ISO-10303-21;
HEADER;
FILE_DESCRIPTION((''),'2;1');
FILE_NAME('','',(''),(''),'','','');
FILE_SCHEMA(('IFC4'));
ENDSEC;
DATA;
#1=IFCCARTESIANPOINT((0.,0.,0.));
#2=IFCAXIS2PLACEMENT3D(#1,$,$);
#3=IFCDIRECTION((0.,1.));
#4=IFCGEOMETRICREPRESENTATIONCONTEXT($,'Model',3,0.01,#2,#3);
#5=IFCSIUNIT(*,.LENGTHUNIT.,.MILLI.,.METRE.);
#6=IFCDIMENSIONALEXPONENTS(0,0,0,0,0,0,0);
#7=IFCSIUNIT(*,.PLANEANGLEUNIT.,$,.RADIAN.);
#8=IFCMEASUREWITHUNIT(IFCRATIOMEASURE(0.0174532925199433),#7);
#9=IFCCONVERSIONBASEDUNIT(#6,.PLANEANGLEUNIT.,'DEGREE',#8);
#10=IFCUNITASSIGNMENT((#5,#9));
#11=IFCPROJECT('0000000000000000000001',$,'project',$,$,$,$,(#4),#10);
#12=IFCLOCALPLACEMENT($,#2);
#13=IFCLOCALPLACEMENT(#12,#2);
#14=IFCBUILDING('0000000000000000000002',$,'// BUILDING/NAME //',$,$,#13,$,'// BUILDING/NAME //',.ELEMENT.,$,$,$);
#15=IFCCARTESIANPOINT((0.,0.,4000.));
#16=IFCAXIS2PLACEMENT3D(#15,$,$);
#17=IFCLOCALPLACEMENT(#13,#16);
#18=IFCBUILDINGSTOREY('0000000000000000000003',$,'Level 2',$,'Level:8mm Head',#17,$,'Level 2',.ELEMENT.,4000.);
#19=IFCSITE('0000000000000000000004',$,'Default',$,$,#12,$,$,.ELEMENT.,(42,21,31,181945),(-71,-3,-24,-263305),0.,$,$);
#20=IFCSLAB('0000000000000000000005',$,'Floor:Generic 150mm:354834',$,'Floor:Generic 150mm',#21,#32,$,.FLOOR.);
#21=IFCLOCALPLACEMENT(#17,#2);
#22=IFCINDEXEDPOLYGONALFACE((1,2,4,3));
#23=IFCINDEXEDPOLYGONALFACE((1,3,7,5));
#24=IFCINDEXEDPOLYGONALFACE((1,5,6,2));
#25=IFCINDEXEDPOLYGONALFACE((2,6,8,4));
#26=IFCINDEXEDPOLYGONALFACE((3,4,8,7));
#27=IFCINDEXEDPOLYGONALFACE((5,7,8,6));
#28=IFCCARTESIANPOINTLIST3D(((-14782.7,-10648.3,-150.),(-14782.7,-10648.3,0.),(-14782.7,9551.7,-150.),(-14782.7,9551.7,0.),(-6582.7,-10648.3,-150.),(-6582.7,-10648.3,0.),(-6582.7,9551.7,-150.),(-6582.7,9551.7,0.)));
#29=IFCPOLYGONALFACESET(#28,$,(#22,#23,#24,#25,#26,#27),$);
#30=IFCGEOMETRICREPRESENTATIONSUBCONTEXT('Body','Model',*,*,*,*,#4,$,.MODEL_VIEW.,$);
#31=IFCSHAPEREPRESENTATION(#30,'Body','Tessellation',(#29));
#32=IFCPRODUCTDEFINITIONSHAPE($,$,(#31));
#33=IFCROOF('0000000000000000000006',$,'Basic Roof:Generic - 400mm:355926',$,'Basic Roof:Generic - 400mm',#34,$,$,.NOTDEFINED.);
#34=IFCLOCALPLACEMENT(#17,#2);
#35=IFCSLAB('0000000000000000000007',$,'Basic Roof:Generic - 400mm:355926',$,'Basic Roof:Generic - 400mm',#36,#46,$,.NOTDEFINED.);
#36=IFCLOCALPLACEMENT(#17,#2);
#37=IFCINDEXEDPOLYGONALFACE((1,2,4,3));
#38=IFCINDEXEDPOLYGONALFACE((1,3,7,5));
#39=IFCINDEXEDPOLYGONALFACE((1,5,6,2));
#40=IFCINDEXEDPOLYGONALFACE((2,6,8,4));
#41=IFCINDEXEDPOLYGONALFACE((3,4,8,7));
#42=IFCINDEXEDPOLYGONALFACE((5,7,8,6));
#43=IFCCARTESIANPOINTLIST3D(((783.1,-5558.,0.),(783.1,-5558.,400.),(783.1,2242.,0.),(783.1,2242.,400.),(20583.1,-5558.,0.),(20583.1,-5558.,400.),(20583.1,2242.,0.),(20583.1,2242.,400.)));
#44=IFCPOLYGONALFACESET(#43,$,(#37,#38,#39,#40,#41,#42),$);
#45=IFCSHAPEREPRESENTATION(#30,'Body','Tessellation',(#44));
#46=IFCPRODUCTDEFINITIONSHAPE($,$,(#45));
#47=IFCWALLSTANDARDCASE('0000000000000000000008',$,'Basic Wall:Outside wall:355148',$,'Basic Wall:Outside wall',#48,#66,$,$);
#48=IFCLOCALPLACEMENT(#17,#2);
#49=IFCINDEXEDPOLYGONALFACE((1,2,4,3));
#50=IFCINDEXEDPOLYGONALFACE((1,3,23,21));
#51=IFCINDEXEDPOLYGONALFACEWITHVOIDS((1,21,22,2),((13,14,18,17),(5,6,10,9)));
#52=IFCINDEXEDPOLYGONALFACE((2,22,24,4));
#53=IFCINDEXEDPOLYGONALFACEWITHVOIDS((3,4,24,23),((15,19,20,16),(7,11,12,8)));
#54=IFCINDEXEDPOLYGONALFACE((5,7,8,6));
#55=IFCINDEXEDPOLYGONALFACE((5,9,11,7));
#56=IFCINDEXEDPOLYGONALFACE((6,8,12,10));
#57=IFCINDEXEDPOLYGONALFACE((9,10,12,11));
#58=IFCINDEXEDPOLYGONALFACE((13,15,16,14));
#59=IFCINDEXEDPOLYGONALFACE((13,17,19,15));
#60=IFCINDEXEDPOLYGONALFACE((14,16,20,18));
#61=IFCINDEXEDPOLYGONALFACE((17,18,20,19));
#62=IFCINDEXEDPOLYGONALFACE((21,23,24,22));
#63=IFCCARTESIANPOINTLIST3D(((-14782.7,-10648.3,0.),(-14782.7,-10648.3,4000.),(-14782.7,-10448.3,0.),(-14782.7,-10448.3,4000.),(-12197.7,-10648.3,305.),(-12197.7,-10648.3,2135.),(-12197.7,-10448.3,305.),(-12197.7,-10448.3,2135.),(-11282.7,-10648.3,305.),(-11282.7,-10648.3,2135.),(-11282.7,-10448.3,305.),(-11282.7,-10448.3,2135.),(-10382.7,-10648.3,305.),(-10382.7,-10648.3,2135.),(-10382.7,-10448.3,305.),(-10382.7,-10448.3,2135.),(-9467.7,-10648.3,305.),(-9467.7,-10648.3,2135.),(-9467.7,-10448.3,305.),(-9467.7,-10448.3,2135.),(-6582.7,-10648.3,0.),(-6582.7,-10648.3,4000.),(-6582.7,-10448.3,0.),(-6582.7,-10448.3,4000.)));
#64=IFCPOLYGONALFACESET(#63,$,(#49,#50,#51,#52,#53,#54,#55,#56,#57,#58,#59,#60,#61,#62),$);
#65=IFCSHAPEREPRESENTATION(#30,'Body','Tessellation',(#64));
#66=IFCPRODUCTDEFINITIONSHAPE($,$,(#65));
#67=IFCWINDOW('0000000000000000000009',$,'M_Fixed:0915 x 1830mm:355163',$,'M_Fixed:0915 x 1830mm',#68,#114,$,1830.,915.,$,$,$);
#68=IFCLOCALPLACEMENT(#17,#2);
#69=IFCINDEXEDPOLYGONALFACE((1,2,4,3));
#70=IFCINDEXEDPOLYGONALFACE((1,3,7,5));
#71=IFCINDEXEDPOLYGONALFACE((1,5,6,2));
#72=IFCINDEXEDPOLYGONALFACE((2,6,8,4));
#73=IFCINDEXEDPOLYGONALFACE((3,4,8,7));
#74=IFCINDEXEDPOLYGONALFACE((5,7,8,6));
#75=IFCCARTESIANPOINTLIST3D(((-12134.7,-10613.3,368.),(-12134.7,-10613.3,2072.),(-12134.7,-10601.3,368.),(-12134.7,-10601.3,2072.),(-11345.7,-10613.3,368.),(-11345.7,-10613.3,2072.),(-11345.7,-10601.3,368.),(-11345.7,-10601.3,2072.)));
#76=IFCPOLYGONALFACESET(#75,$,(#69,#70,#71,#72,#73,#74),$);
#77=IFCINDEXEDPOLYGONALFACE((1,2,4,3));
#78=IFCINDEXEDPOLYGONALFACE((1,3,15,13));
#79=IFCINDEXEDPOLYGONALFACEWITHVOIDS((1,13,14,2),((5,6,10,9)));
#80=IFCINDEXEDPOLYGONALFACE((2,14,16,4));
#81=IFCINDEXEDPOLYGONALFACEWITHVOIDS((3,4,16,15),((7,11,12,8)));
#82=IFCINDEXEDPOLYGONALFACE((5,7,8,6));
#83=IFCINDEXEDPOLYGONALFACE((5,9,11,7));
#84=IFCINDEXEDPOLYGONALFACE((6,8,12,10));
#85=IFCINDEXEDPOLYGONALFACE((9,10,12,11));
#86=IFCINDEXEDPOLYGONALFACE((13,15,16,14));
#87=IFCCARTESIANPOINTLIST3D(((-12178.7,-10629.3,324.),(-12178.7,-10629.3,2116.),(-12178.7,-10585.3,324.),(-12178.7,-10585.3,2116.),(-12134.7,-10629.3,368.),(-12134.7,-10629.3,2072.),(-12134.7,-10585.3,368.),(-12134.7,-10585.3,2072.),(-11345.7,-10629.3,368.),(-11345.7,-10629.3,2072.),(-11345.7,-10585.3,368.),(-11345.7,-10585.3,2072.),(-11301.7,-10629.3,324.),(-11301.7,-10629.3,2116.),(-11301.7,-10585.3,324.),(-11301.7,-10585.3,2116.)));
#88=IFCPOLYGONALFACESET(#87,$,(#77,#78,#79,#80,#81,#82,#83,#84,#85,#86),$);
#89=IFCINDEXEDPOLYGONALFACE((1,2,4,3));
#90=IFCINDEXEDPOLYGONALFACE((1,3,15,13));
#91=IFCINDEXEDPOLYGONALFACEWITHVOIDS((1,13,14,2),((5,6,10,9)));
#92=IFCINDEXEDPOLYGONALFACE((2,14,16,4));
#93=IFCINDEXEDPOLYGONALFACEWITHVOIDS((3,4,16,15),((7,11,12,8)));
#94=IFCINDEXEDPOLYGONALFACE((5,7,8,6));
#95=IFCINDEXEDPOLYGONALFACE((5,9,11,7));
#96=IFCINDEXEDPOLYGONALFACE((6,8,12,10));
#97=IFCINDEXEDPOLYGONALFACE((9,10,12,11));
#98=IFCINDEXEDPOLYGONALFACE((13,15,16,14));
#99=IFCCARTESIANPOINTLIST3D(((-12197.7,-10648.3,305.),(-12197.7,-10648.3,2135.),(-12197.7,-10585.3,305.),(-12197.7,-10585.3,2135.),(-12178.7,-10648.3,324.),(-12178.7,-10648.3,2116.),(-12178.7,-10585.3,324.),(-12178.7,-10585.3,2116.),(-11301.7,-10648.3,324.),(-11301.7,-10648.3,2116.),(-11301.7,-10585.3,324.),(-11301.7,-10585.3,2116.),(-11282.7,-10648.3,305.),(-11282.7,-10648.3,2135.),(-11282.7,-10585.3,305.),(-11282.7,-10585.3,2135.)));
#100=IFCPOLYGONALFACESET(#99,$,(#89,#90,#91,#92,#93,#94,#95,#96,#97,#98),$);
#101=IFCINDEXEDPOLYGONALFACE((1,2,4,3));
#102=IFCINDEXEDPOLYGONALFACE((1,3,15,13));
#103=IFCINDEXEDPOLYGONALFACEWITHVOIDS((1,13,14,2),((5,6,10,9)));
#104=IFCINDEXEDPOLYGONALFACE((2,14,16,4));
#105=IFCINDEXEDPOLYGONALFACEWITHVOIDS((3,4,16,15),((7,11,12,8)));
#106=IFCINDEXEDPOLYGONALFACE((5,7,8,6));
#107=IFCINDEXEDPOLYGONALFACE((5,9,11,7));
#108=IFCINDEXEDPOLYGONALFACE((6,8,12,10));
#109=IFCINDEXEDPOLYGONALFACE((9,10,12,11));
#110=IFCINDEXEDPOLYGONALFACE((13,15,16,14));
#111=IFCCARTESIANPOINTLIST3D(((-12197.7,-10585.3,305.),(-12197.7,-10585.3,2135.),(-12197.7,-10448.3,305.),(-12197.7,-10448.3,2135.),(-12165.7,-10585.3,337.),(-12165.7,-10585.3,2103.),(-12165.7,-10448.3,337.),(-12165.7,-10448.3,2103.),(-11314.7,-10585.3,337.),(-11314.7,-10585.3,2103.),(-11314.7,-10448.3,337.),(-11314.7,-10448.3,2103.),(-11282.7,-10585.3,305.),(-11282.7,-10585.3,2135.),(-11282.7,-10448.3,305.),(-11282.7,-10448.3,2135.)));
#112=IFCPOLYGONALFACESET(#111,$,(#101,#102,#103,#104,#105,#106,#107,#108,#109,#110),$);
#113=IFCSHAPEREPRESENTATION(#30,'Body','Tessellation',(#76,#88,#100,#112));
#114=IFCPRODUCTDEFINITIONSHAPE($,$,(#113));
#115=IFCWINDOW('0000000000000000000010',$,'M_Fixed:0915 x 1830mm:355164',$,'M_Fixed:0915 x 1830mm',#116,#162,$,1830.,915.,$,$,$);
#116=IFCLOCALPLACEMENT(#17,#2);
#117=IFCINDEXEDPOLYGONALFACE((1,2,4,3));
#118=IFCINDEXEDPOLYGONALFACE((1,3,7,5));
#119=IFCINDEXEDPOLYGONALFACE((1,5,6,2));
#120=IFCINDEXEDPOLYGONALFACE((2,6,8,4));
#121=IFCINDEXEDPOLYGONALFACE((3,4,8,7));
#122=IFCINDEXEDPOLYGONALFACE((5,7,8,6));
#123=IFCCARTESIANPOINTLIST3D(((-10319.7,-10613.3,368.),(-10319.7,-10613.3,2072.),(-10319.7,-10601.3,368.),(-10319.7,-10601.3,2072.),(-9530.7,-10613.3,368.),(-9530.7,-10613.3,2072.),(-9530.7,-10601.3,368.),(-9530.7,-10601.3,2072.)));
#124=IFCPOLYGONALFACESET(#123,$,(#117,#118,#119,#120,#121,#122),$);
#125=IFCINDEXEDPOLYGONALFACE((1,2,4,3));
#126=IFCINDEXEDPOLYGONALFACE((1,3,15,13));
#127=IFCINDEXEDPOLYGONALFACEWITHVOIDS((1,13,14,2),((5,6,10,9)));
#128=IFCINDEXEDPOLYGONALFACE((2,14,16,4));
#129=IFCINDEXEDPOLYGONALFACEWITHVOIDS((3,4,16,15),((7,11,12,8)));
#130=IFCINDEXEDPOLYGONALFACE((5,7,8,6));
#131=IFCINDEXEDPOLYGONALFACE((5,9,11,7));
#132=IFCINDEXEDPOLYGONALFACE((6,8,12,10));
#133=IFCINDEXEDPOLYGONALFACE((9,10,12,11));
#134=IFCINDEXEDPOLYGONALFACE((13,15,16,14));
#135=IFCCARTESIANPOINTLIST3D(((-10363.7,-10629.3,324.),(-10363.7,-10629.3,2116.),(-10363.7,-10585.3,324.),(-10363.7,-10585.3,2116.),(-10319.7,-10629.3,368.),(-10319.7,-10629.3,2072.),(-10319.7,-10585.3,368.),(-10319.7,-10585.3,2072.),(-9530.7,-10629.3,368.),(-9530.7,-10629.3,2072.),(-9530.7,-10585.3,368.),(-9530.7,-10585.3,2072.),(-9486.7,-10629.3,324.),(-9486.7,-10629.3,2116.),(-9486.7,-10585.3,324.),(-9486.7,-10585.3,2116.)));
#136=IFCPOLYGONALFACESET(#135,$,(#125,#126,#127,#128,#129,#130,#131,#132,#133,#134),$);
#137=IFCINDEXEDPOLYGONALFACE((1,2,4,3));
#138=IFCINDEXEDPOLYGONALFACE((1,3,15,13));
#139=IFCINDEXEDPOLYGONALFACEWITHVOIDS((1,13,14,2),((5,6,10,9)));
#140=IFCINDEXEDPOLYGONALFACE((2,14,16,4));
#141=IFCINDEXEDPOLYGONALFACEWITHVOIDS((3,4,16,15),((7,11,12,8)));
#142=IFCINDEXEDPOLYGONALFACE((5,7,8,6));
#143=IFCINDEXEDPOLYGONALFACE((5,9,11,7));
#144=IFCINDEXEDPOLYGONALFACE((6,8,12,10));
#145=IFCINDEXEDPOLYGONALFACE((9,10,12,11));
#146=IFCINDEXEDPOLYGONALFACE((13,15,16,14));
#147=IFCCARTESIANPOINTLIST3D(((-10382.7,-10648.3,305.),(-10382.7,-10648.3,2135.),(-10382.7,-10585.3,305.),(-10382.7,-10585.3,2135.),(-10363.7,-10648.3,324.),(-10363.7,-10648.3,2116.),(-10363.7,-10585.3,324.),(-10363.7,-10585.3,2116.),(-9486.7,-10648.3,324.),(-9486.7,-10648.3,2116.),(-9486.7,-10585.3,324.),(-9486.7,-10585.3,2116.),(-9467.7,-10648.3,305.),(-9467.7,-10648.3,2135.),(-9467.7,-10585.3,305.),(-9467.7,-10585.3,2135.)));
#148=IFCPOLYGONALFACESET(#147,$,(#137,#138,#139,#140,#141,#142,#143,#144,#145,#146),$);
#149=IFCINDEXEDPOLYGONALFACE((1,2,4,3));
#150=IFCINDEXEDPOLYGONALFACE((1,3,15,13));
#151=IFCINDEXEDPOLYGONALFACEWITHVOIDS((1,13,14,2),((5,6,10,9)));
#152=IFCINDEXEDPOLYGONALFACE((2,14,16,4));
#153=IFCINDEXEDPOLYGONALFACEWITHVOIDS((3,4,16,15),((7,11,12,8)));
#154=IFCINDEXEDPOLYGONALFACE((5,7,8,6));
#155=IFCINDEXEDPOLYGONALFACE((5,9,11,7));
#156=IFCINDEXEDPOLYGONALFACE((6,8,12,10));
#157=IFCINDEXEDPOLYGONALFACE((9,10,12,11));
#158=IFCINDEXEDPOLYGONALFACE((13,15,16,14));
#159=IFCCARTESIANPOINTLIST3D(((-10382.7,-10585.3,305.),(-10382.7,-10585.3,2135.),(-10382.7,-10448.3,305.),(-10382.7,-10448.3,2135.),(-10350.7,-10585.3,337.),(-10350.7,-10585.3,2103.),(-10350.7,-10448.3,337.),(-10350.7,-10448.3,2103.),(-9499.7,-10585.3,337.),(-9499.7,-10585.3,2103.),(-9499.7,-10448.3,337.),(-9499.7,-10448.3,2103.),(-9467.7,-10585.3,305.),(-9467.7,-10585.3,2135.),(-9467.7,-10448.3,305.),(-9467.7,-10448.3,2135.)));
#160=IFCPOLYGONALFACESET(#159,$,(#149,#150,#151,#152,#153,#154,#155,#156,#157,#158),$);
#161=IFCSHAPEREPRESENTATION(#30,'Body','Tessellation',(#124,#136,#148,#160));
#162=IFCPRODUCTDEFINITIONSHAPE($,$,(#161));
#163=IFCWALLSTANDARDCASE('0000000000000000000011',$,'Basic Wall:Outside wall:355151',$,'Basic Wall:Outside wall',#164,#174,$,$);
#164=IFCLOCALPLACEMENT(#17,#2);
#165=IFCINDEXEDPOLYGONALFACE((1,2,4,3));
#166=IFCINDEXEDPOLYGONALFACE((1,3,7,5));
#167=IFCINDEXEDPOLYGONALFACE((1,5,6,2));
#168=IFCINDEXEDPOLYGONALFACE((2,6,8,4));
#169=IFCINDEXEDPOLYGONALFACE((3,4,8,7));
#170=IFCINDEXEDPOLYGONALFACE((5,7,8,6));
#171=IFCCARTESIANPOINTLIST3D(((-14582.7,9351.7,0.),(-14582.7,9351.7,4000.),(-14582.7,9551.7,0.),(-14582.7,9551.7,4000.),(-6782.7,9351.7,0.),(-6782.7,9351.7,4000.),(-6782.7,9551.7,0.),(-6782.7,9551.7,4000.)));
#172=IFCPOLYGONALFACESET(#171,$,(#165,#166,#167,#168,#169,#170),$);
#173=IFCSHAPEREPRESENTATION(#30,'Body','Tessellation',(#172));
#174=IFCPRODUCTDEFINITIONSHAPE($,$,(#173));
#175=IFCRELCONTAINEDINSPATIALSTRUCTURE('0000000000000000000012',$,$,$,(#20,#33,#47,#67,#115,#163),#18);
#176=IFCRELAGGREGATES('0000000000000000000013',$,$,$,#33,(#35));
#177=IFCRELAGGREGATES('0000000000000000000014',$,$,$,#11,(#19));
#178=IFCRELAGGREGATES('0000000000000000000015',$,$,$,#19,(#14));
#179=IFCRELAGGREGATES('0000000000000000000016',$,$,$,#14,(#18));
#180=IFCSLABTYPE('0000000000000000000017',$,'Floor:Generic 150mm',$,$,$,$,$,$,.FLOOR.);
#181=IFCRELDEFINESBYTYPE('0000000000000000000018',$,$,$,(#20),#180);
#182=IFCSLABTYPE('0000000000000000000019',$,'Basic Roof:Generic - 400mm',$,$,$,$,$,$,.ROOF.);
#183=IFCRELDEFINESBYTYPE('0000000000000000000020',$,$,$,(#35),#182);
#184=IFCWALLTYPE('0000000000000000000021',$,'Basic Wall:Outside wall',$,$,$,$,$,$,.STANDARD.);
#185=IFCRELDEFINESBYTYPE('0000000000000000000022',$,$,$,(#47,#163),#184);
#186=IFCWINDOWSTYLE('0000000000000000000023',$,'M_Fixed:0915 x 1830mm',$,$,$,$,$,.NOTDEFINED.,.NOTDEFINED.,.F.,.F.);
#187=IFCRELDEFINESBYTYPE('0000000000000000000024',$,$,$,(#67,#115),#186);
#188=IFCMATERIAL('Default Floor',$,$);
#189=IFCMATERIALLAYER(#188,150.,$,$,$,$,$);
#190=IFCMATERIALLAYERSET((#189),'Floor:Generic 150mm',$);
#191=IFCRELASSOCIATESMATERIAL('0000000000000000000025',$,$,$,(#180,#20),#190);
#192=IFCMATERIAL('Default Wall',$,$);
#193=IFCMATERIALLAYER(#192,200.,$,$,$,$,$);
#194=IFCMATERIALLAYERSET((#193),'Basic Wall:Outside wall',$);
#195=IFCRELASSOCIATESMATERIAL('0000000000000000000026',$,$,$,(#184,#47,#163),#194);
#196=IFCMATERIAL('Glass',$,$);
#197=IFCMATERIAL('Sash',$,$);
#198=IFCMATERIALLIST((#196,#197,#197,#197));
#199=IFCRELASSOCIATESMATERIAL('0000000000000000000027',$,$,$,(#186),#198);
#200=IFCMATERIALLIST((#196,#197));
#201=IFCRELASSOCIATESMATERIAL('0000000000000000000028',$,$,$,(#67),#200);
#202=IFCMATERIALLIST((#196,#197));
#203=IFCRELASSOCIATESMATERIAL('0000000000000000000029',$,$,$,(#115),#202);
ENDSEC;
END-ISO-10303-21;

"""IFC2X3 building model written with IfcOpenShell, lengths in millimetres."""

from ifc_helpers import new_model, entity, si_unit, converted_unit, direction, frame, frame_2d, origin, place, context, subcontext, project, spatial, polyline, rectangle, outline, extrude, source, transform, mapped, material, material_list, layer, layer_set, layer_usage, type_object, type_shapes, element, fill, aggregate, save


model = new_model("IFC2X3")

# Units and contexts
model_context = context("Model", 3, precision=0.01, world=origin(), true_north=direction((0.0, 1.0)))
body_context = subcontext(model_context, "Body", "Model", "MODEL_VIEW")
ifc_project = project(units=[si_unit("LENGTHUNIT", "METRE", prefix="MILLI"), converted_unit("PLANEANGLEUNIT", "DEGREE", entity("IfcRatioMeasure", 0.0174532925199433), si_unit("PLANEANGLEUNIT", "RADIAN"), dimensions=[0, 0, 0, 0, 0, 0, 0])], contexts=[model_context])

# Site, building, storey
site_placement = place(None, origin())
site = spatial("IfcSite", under=ifc_project, at=site_placement, Name="Default", CompositionType="ELEMENT", RefLatitude=(42, 21, 31, 181945), RefLongitude=(-71, -3, -24, -263305), RefElevation=0.0)
building_placement = place(site_placement, origin())
building = spatial("IfcBuilding", under=site, at=building_placement, Name="// BUILDING/NAME //", LongName="// BUILDING/NAME //", CompositionType="ELEMENT")
storey_placement = place(building_placement, frame((0.0, 0.0, 4000.0)))
storey = spatial("IfcBuildingStorey", under=building, at=storey_placement, Name="Level 2", ObjectType="Level:8mm Head", LongName="Level 2", CompositionType="ELEMENT", Elevation=4000.0)

# Slab
ifc_material_1 = material(Name="Default Floor")
ifc_layer_1 = layer(ifc_material_1, 150.0)
ifc_layer_set_1 = layer_set([ifc_layer_1], Name="Floor:Generic 150mm")
ifc_layer_usage_1 = layer_usage(ifc_layer_set_1, "AXIS3", "POSITIVE", 0.0)
slab_type_1 = type_object("IfcSlabType", Name="Floor:Generic 150mm", PredefinedType="FLOOR", material=ifc_layer_set_1)
slab_1_placement = place(storey_placement, origin())
element("IfcSlab", 1, at=slab_1_placement, inside=storey, type_object=slab_type_1, material=ifc_layer_usage_1, Name="Floor:Generic 150mm:354834", ObjectType="Floor:Generic 150mm", PredefinedType="FLOOR", context=body_context, shape_type="SweptSolid", body=[
    extrude(rectangle(XDim=20200.0, YDim=8200.0, at=frame_2d((0.0, 0.0), x_axis=(1.0, 0.0))), frame((-10682.7, -548.3, 0.0), z_axis=(0.0, 0.0, -1.0), x_axis=(0.0, 1.0, 0.0)), (0.0, 0.0, 1.0), 150.0),
])

# Roof, slab
roof_placement = place(storey_placement, frame((783.1, -5558.0, 0.0)))
roof = element("IfcRoof", 2, at=roof_placement, inside=storey, Name="Basic Roof:Generic - 400mm:355926", ObjectType="Basic Roof:Generic - 400mm", ShapeType="NOTDEFINED")
slab_type_2 = type_object("IfcSlabType", Name="Basic Roof:Generic - 400mm", PredefinedType="ROOF")
slab_2_placement = place(roof_placement, origin())
slab_2 = element("IfcSlab", 3, at=slab_2_placement, type_object=slab_type_2, Name="Basic Roof:Generic - 400mm:355926", ObjectType="Basic Roof:Generic - 400mm", PredefinedType="NOTDEFINED", context=body_context, shape_type="SweptSolid", body=[
    extrude(rectangle(XDim=7800.0, YDim=19800.0, at=frame_2d((0.0, 0.0), x_axis=(0.0, 1.0))), frame((9900.0, 3900.0, 0.0)), (0.0, 0.0, 1.0), 400.0),
])
aggregate(roof, [slab_2])

# Wall, openings, windows
ifc_material_2 = material(Name="Default Wall")
ifc_layer_2 = layer(ifc_material_2, 200.0)
ifc_layer_set_2 = layer_set([ifc_layer_2], Name="Basic Wall:Outside wall")
ifc_layer_usage_2 = layer_usage(ifc_layer_set_2, "AXIS2", "NEGATIVE", 100.0)
wall_type = type_object("IfcWallType", Name="Basic Wall:Outside wall", PredefinedType="STANDARD", material=ifc_layer_set_2)
wall_1_placement = place(storey_placement, frame((-14782.7, -10548.3, 0.0)))
wall_1 = element("IfcWallStandardCase", 4, at=wall_1_placement, inside=storey, type_object=wall_type, material=ifc_layer_usage_2, Name="Basic Wall:Outside wall:355148", ObjectType="Basic Wall:Outside wall", context=body_context, shape_type="SweptSolid", body=[
    extrude(rectangle(XDim=8200.0, YDim=200.0, at=frame_2d((4100.0, 0.0), x_axis=(-1.0, 0.0))), origin(), (0.0, 0.0, 1.0), 4000.0),
])
opening_1_placement = place(wall_1_placement, frame((3500.0, 100.0, 305.0)))
opening_1 = element("IfcOpeningElement", 5, at=opening_1_placement, cuts=wall_1, ObjectType="Opening", context=body_context, shape_type="SweptSolid", body=[
    extrude(rectangle(XDim=1830.0, YDim=915.0, at=frame_2d((915.0, 457.5), x_axis=(1.0, 0.0))), frame((0.0, 0.0, 0.0), z_axis=(0.0, -1.0, 0.0), x_axis=(0.0, 0.0, 1.0)), (0.0, 0.0, 1.0), 200.0),
])
opening_2_placement = place(wall_1_placement, frame((5315.0, 100.0, 305.0)))
opening_2 = element("IfcOpeningElement", 6, at=opening_2_placement, cuts=wall_1, ObjectType="Opening", context=body_context, shape_type="SweptSolid", body=[
    extrude(rectangle(XDim=1830.0, YDim=915.0, at=frame_2d((915.0, 457.5), x_axis=(1.0, 0.0))), frame((0.0, 0.0, 0.0), z_axis=(0.0, -1.0, 0.0), x_axis=(0.0, 0.0, 1.0)), (0.0, 0.0, 1.0), 200.0),
])
ifc_material_3 = material(Name="Glass")
ifc_material_4 = material(Name="Sash")
ifc_material_list_1 = material_list([ifc_material_3, ifc_material_4])
ifc_material_list_2 = material_list([ifc_material_3, ifc_material_4, ifc_material_4, ifc_material_4])
window_style = type_object("IfcWindowStyle", Name="M_Fixed:0915 x 1830mm", ConstructionType="NOTDEFINED", OperationType="NOTDEFINED", ParameterTakesPrecedence=False, Sizeable=False, material=ifc_material_list_2)
shared_shape = source(origin(), body_context, "Body", "SweptSolid", [
    extrude(rectangle(XDim=12.0, YDim=789.0, at=frame_2d((0.0, 0.0), x_axis=(1.0, 0.0))), frame((457.5, 159.0, 63.0), z_axis=(0.0, 0.0, 1.0), x_axis=(0.0, -1.0, 0.0)), (0.0, 0.0, 1.0), 1704.0),
    extrude(outline(polyline([(-438.5, -896.0), (438.5, -896.0), (438.5, 896.0), (-438.5, 896.0), (-438.5, -896.0)]), holes=[polyline([(-394.5, -852.0), (-394.5, 852.0), (394.5, 852.0), (394.5, -852.0), (-394.5, -852.0)])]), frame((457.5, 137.0, 915.0), z_axis=(0.0, 1.0, 0.0), x_axis=(1.0, 0.0, 0.0)), (0.0, 0.0, 1.0), 44.0),
    extrude(outline(polyline([(-457.5, -915.0), (457.5, -915.0), (457.5, 915.0), (-457.5, 915.0), (-457.5, -915.0)]), holes=[polyline([(-438.5, -896.0), (-438.5, 896.0), (438.5, 896.0), (438.5, -896.0), (-438.5, -896.0)])]), frame((457.5, 137.0, 915.0), z_axis=(0.0, 1.0, 0.0), x_axis=(1.0, 0.0, 0.0)), (0.0, 0.0, 1.0), 63.0),
    extrude(outline(polyline([(-457.5, -915.0), (457.5, -915.0), (457.5, 915.0), (-457.5, 915.0), (-457.5, -915.0)]), holes=[polyline([(-425.5, -883.0), (-425.5, 883.0), (425.5, 883.0), (425.5, -883.0), (-425.5, -883.0)])]), frame((457.5, 0.0, 915.0), z_axis=(0.0, 1.0, 0.0), x_axis=(1.0, 0.0, 0.0)), (0.0, 0.0, 1.0), 137.0),
])
type_shapes(window_style, [shared_shape])
window_1_placement = place(opening_1_placement, frame((0.0, 0.0, 0.0), z_axis=(0.0, 0.0, 1.0), x_axis=(-1.0, 0.0, 0.0)))
window_1 = element("IfcWindow", 7, at=window_1_placement, inside=storey, type_object=window_style, material=ifc_material_list_1, Name="M_Fixed:0915 x 1830mm:355163", ObjectType="M_Fixed:0915 x 1830mm", OverallHeight=1830.0, OverallWidth=915.0, context=body_context, shape_type="MappedRepresentation", body=[
    mapped(shared_shape, transform((0.0, 0.0, 0.0), scale=1.0)),
])
fill(opening_1, window_1)
ifc_material_list_3 = material_list([ifc_material_3, ifc_material_4])
window_2_placement = place(opening_2_placement, frame((0.0, 0.0, 0.0), z_axis=(0.0, 0.0, 1.0), x_axis=(-1.0, 0.0, 0.0)))
window_2 = element("IfcWindow", 8, at=window_2_placement, inside=storey, type_object=window_style, material=ifc_material_list_3, Name="M_Fixed:0915 x 1830mm:355164", ObjectType="M_Fixed:0915 x 1830mm", OverallHeight=1830.0, OverallWidth=915.0, context=body_context, shape_type="MappedRepresentation", body=[
    mapped(shared_shape, transform((0.0, 0.0, 0.0), scale=1.0)),
])
fill(opening_2, window_2)

# Wall
ifc_layer_usage_3 = layer_usage(ifc_layer_set_2, "AXIS2", "NEGATIVE", 100.0)
wall_2_placement = place(storey_placement, frame((-6782.7, 9451.7, 0.0), z_axis=(0.0, 0.0, 1.0), x_axis=(-1.0, 0.0, 0.0)))
element("IfcWallStandardCase", 9, at=wall_2_placement, inside=storey, type_object=wall_type, material=ifc_layer_usage_3, Name="Basic Wall:Outside wall:355151", ObjectType="Basic Wall:Outside wall", context=body_context, shape_type="SweptSolid", body=[
    extrude(rectangle(XDim=7800.0, YDim=200.0, at=frame_2d((3900.0, 0.0), x_axis=(-1.0, 0.0))), origin(), (0.0, 0.0, 1.0), 4000.0),
])

save(model, "model.ifc")
